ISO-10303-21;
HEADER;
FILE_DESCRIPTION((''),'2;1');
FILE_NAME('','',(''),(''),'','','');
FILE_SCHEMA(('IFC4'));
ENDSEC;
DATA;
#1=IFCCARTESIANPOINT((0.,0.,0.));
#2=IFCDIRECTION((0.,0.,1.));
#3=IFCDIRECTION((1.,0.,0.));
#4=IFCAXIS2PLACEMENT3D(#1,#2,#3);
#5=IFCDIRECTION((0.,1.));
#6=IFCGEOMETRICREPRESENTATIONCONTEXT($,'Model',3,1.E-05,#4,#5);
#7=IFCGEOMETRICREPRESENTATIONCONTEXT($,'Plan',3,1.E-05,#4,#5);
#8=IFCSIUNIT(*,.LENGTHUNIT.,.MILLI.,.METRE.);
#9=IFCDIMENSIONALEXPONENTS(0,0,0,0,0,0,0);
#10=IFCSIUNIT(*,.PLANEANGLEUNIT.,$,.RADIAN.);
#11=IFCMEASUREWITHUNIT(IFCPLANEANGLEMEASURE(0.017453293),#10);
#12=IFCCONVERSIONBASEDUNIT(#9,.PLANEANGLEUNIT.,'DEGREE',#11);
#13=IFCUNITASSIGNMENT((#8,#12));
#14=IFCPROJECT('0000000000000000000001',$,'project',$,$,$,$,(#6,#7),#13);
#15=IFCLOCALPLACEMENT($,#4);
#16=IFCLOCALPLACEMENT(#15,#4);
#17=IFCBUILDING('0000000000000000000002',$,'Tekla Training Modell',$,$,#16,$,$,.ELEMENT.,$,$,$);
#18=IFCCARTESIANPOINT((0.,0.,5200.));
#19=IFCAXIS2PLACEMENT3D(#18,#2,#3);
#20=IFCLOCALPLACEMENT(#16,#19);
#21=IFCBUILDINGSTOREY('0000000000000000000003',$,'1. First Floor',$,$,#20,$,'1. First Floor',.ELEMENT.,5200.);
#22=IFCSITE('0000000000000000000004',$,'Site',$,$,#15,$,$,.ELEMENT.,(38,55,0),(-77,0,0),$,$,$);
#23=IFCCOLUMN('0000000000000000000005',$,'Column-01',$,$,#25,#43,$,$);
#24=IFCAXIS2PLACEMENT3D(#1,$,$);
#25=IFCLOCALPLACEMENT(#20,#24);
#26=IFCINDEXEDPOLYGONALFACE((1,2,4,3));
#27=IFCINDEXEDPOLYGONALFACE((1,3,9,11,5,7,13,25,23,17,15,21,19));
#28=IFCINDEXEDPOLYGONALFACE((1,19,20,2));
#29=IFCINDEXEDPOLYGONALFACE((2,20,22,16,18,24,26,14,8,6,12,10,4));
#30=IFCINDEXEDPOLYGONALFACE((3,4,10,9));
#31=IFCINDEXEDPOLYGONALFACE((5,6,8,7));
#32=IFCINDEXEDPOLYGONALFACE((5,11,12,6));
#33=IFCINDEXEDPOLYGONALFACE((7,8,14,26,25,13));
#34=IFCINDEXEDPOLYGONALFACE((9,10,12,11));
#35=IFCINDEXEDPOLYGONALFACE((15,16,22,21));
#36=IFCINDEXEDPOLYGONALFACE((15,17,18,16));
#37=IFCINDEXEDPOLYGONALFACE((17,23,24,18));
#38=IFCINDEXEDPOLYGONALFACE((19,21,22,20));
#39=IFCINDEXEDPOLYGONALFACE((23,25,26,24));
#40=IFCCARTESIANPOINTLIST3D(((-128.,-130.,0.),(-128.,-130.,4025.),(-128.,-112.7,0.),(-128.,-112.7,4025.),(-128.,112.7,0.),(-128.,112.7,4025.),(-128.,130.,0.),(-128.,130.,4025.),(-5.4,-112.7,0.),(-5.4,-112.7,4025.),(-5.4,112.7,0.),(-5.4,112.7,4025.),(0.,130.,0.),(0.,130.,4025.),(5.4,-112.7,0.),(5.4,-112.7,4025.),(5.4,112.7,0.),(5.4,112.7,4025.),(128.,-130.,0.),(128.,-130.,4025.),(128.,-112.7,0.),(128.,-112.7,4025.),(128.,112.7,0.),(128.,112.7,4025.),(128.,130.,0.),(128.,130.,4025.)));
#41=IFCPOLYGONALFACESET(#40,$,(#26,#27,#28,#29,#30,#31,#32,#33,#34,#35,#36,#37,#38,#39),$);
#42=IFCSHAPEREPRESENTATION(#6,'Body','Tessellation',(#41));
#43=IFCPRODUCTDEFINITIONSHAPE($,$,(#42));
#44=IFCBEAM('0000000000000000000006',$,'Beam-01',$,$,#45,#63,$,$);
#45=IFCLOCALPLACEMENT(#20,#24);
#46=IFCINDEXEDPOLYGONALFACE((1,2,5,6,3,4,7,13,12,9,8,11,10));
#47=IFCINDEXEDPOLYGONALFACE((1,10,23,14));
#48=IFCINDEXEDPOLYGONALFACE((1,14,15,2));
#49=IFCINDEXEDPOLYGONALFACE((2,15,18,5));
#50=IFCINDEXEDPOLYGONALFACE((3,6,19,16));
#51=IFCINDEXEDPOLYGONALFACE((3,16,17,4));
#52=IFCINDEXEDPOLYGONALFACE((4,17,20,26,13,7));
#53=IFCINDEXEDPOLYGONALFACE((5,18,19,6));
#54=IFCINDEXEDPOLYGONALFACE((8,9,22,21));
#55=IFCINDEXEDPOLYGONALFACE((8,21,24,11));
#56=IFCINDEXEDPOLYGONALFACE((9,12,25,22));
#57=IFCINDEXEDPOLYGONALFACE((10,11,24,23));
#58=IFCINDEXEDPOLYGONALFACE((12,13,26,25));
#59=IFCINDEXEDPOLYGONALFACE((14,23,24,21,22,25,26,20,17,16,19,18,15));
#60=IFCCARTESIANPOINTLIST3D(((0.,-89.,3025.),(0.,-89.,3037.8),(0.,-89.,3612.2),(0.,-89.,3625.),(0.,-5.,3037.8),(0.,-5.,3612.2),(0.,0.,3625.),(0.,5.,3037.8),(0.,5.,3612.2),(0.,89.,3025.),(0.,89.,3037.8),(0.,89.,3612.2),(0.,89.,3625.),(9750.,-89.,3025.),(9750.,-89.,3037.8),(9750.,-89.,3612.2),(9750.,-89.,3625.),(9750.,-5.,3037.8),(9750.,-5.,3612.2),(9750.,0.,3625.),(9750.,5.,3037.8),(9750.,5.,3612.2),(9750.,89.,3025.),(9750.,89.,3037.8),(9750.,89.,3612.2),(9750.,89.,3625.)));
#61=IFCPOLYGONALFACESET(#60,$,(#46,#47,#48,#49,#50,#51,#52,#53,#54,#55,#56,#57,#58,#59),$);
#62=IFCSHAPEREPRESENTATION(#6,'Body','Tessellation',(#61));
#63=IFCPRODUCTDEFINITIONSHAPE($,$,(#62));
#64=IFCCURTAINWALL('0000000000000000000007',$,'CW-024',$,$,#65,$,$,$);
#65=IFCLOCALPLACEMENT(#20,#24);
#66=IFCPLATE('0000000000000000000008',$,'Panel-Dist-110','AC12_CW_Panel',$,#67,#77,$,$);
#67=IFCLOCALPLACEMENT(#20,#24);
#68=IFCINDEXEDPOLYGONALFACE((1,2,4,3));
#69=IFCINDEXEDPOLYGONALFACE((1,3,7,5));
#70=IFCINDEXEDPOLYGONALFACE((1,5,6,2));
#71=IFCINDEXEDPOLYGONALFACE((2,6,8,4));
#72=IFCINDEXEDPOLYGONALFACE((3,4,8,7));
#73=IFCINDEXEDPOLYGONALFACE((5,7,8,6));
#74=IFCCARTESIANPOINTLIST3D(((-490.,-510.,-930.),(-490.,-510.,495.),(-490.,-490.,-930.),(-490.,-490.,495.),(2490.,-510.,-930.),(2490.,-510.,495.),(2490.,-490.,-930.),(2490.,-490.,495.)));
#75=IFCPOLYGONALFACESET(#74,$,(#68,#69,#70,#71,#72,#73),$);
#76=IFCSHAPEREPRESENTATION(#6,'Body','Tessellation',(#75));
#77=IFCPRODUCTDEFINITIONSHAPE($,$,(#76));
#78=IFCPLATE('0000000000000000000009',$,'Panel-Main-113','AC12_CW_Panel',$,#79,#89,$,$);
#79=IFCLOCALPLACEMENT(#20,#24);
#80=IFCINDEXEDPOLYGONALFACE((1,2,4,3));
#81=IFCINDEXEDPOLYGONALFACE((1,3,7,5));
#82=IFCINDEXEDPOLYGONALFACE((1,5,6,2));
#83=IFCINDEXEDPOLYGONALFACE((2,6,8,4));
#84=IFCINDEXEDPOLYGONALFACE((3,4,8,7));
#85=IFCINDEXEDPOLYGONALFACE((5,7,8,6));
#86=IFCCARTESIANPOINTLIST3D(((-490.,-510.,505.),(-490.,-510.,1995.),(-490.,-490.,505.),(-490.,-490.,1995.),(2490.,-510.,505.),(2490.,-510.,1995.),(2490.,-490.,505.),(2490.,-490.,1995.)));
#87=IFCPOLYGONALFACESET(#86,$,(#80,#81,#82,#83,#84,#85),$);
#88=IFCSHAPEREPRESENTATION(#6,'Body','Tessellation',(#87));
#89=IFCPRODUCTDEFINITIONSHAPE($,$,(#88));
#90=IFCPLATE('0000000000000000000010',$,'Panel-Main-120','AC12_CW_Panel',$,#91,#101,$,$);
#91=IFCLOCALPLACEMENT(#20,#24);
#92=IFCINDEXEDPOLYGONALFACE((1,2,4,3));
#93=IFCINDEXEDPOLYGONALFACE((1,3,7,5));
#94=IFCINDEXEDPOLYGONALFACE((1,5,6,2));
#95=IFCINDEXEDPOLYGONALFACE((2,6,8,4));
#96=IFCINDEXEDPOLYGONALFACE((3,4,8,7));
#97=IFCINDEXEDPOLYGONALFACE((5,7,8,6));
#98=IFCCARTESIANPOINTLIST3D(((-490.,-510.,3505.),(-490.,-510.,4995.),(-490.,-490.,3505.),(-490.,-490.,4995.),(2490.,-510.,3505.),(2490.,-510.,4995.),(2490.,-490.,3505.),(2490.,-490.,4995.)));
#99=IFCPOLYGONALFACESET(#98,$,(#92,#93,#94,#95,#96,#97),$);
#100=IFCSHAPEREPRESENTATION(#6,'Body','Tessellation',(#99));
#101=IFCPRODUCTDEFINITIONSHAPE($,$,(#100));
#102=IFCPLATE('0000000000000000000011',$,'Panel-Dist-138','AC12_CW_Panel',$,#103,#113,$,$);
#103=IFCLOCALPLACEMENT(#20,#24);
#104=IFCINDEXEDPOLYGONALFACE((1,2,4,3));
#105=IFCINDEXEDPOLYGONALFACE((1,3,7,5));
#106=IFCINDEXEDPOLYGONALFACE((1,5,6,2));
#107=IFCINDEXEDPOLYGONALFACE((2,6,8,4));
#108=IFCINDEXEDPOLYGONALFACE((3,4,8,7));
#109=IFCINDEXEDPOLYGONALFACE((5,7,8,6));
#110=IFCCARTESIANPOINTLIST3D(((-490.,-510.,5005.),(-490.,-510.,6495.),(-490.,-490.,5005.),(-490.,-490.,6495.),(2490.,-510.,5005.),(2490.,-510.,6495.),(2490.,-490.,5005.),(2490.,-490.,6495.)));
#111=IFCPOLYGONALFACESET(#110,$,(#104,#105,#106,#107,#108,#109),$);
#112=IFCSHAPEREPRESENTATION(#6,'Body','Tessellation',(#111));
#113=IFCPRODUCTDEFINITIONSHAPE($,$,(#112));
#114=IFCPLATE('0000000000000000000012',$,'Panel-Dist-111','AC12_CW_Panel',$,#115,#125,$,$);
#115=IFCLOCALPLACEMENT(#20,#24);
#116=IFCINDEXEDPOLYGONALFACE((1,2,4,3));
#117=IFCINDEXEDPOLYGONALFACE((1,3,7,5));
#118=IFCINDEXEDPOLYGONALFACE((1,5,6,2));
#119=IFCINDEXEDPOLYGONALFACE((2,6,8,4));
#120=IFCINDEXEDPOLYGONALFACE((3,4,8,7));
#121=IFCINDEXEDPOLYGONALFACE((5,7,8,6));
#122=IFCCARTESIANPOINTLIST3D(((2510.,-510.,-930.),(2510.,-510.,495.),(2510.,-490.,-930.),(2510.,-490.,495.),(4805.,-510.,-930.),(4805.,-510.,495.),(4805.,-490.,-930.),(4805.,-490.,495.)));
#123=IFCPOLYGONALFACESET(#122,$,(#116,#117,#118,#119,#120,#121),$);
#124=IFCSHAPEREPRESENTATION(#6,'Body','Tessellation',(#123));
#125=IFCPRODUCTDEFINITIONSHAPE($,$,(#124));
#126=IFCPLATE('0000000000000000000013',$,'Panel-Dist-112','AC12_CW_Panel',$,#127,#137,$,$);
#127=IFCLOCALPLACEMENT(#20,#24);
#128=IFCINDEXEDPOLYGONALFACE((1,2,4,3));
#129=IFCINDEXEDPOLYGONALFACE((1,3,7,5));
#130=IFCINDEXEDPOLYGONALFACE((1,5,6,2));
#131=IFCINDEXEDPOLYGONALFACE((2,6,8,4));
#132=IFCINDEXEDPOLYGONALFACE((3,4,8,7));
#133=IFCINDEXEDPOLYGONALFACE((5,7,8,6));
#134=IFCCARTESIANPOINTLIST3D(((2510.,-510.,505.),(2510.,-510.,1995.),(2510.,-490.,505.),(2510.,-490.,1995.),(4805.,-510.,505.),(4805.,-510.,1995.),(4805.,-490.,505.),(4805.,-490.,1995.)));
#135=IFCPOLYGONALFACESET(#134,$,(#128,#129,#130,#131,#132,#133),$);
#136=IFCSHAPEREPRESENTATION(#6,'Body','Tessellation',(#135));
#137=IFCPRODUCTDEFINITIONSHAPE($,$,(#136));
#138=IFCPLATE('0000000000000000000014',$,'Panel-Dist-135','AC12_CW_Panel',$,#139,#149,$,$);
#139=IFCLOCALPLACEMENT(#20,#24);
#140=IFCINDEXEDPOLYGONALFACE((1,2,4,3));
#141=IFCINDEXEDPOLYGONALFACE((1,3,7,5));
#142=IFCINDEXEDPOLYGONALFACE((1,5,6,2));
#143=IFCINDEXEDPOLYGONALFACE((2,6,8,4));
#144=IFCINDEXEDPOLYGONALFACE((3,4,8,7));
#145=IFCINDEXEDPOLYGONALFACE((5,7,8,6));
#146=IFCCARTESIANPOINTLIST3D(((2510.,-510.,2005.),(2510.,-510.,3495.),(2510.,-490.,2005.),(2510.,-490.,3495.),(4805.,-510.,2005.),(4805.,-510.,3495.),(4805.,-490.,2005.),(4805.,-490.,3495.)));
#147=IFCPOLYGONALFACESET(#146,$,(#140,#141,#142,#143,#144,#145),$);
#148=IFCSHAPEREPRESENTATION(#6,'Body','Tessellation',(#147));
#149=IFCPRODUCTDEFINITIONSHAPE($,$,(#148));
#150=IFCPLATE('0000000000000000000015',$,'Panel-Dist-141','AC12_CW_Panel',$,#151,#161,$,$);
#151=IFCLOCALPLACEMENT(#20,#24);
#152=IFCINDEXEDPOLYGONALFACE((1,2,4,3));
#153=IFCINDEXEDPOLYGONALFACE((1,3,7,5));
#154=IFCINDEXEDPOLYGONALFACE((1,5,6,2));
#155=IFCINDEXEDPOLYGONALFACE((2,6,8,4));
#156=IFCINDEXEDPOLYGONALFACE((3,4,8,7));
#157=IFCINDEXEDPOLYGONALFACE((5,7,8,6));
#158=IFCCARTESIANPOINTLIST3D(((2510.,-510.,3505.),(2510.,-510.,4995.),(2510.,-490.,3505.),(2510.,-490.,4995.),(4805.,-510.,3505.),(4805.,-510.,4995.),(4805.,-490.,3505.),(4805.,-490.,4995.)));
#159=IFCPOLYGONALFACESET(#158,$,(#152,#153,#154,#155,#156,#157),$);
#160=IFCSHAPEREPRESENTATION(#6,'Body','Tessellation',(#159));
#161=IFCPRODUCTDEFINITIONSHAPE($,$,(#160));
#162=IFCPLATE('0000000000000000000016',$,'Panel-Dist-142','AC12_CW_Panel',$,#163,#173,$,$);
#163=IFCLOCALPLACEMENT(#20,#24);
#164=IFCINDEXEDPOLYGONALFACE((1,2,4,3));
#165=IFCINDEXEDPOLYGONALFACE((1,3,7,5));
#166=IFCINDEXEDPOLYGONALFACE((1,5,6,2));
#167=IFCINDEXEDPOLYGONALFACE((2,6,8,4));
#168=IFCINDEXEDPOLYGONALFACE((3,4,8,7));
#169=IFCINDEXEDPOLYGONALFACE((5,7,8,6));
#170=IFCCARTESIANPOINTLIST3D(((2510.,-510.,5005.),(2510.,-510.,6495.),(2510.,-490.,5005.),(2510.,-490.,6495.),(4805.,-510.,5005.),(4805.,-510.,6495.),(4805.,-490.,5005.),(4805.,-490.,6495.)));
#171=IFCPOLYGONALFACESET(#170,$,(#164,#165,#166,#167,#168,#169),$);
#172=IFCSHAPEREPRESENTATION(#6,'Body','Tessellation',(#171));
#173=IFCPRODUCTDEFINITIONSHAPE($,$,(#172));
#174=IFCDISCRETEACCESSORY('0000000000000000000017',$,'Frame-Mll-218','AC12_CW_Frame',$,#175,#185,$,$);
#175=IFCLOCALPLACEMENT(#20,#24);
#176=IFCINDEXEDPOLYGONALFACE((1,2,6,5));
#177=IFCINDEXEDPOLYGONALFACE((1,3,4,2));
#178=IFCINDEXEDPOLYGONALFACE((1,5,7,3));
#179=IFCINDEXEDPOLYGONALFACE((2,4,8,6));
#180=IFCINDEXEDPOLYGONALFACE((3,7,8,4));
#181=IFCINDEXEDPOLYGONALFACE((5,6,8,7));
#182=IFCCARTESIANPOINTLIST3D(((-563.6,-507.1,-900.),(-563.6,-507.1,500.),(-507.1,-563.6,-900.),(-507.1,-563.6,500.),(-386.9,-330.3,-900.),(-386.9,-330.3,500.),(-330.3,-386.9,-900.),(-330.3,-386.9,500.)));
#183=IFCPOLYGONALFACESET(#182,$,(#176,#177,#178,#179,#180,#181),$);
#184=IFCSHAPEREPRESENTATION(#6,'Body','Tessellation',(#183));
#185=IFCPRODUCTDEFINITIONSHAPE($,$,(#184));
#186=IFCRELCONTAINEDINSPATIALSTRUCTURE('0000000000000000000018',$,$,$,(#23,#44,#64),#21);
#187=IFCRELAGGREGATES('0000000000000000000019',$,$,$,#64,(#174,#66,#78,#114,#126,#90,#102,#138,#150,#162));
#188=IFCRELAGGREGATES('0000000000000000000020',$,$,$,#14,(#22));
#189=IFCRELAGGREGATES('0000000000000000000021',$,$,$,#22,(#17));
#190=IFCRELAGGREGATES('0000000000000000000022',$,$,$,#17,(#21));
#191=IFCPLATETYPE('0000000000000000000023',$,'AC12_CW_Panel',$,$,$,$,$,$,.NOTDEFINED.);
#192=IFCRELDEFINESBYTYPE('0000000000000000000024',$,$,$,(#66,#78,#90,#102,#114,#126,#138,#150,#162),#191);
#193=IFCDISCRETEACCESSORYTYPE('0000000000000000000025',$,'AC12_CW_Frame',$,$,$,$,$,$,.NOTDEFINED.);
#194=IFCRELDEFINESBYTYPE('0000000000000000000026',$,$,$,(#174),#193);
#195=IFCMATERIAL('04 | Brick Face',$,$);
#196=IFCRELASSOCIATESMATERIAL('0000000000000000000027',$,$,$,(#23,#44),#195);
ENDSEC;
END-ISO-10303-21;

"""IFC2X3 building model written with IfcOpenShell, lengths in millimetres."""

from ifc_helpers import new_model, entity, si_unit, converted_unit, direction, frame, origin_with_axes, place, context, project, spatial, polyline, outline, extrude, source, transform, mapped, material, type_object, element, aggregate, save


model = new_model("IFC2X3")

# Units and contexts
model_context = context("Model", 3, precision=1e-05, world=origin_with_axes(), true_north=direction((0.0, 1.0)))
plan_context = context("Plan", 3, precision=1e-05, world=origin_with_axes(), true_north=direction((0.0, 1.0)))
ifc_project = project(units=[si_unit("LENGTHUNIT", "METRE", prefix="MILLI"), converted_unit("PLANEANGLEUNIT", "DEGREE", entity("IfcPlaneAngleMeasure", 0.017453293), si_unit("PLANEANGLEUNIT", "RADIAN"), dimensions=[0, 0, 0, 0, 0, 0, 0])], contexts=[model_context, plan_context])

# Site, building, storey
site_placement = place(None, origin_with_axes())
site = spatial("IfcSite", under=ifc_project, at=site_placement, Name="Site", CompositionType="ELEMENT", RefLatitude=(38, 55, 0), RefLongitude=(-77, 0, 0))
building_placement = place(site_placement, origin_with_axes())
building = spatial("IfcBuilding", under=site, at=building_placement, Name="Tekla Training Modell", CompositionType="ELEMENT")
storey_placement = place(building_placement, frame((0.0, 0.0, 5200.0), z_axis=(0.0, 0.0, 1.0), x_axis=(1.0, 0.0, 0.0)))
storey = spatial("IfcBuildingStorey", under=building, at=storey_placement, Name="1. First Floor", LongName="1. First Floor", CompositionType="ELEMENT", Elevation=5200.0)

# Column
ifc_material = material(Name="04 | Brick Face")
column_placement = place(storey_placement, origin_with_axes())
element("IfcColumn", 1, at=column_placement, inside=storey, material=ifc_material, Name="Column-01", context=model_context, shape_type="SweptSolid", body=[
    extrude(outline(polyline([(0.0, 130.0), (-128.0, 130.0), (-128.0, 112.7), (-5.3, 112.7), (-5.3, -112.7), (-128.0, -112.7), (-128.0, -130.0), (128.0, -130.0), (128.0, -112.7), (5.3, -112.7), (5.3, 112.7), (128.0, 112.7), (128.0, 130.0), (0.0, 130.0)])), origin_with_axes(), (0.0, 0.0, 1.0), 4025.0),
])

# Beam
beam_placement = place(storey_placement, frame((0.0, 0.0, 3325.0), z_axis=(0.0, 0.0, 1.0), x_axis=(0.0, -1.0, 0.0)))
element("IfcBeam", 2, at=beam_placement, inside=storey, material=ifc_material, Name="Beam-01", context=model_context, shape_type="SweptSolid", body=[
    extrude(outline(polyline([(0.0, 300.0), (-89.0, 300.0), (-89.0, 287.2), (-5.0, 287.2), (-5.0, -287.2), (-89.0, -287.2), (-89.0, -300.0), (89.0, -300.0), (89.0, -287.2), (5.0, -287.2), (5.0, 287.2), (89.0, 287.2), (89.0, 300.0), (0.0, 300.0)])), frame((0.0, 9750.0, 0.0), z_axis=(0.0, -1.0, 0.0), x_axis=(1.0, 0.0, 0.0)), (0.0, 0.0, 1.0), 9750.0),
])

# Curtain wall, plates, discrete accessory
curtain_wall_placement = place(storey_placement, frame((-500.0, 6800.2, -1000.0), z_axis=(0.0, 0.0, 1.0), x_axis=(0.0, -1.0, 0.0)))
curtain_wall = element("IfcCurtainWall", 3, at=curtain_wall_placement, inside=storey, Name="CW-024")
plate_type = type_object("IfcPlateType", Name="AC12_CW_Panel", PredefinedType="NOTDEFINED")
shared_shape_1 = source(origin_with_axes(), model_context, "Body", "SweptSolid", [
    extrude(outline(polyline([(0.0, 0.0), (2980.0, 0.0), (2980.0, -20.0), (0.0, -20.0), (0.0, 0.0)])), origin_with_axes(), (0.0, 0.0, 1.0), 1425.0),
])
plate_1_placement = place(storey_placement, frame((-490.0, -490.0, -930.0), z_axis=(0.0, 0.0, 1.0), x_axis=(1.0, 0.0, 0.0)))
plate_1 = element("IfcPlate", 4, at=plate_1_placement, type_object=plate_type, Name="Panel-Dist-110", Description="AC12_CW_Panel", context=model_context, shape_type="MappedRepresentation", body=[
    mapped(shared_shape_1, transform((0.0, 0.0, 0.0), scale=1.0)),
])
shared_shape_2 = source(origin_with_axes(), model_context, "Body", "SweptSolid", [
    extrude(outline(polyline([(0.0, 0.0), (2980.0, 0.0), (2980.0, -20.0), (0.0, -20.0), (0.0, 0.0)])), origin_with_axes(), (0.0, 0.0, 1.0), 1490.0),
])
plate_2_placement = place(storey_placement, frame((-490.0, -490.0, 505.0), z_axis=(0.0, 0.0, 1.0), x_axis=(1.0, 0.0, 0.0)))
plate_2 = element("IfcPlate", 5, at=plate_2_placement, type_object=plate_type, Name="Panel-Main-113", Description="AC12_CW_Panel", context=model_context, shape_type="MappedRepresentation", body=[
    mapped(shared_shape_2, transform((0.0, 0.0, 0.0), scale=1.0)),
])
plate_3_placement = place(storey_placement, frame((-490.0, -490.0, 3505.0), z_axis=(0.0, 0.0, 1.0), x_axis=(1.0, 0.0, 0.0)))
plate_3 = element("IfcPlate", 6, at=plate_3_placement, type_object=plate_type, Name="Panel-Main-120", Description="AC12_CW_Panel", context=model_context, shape_type="MappedRepresentation", body=[
    mapped(shared_shape_2, transform((0.0, 0.0, 0.0), scale=1.0)),
])
plate_4_placement = place(storey_placement, frame((-490.0, -490.0, 5005.0), z_axis=(0.0, 0.0, 1.0), x_axis=(1.0, 0.0, 0.0)))
plate_4 = element("IfcPlate", 7, at=plate_4_placement, type_object=plate_type, Name="Panel-Dist-138", Description="AC12_CW_Panel", context=model_context, shape_type="MappedRepresentation", body=[
    mapped(shared_shape_2, transform((0.0, 0.0, 0.0), scale=1.0)),
])
shared_shape_3 = source(origin_with_axes(), model_context, "Body", "SweptSolid", [
    extrude(outline(polyline([(0.0, 0.0), (2295.0, 0.0), (2295.0, -20.0), (0.0, -20.0), (0.0, 0.0)])), origin_with_axes(), (0.0, 0.0, 1.0), 1425.0),
])
plate_5_placement = place(storey_placement, frame((2510.0, -490.0, -930.0), z_axis=(0.0, 0.0, 1.0), x_axis=(1.0, 0.0, 0.0)))
plate_5 = element("IfcPlate", 8, at=plate_5_placement, type_object=plate_type, Name="Panel-Dist-111", Description="AC12_CW_Panel", context=model_context, shape_type="MappedRepresentation", body=[
    mapped(shared_shape_3, transform((0.0, 0.0, 0.0), scale=1.0)),
])
shared_shape_4 = source(origin_with_axes(), model_context, "Body", "SweptSolid", [
    extrude(outline(polyline([(0.0, 0.0), (2295.0, 0.0), (2295.0, -20.0), (0.0, -20.0), (0.0, 0.0)])), origin_with_axes(), (0.0, 0.0, 1.0), 1490.0),
])
plate_6_placement = place(storey_placement, frame((2510.0, -490.0, 505.0), z_axis=(0.0, 0.0, 1.0), x_axis=(1.0, 0.0, 0.0)))
plate_6 = element("IfcPlate", 9, at=plate_6_placement, type_object=plate_type, Name="Panel-Dist-112", Description="AC12_CW_Panel", context=model_context, shape_type="MappedRepresentation", body=[
    mapped(shared_shape_4, transform((0.0, 0.0, 0.0), scale=1.0)),
])
plate_7_placement = place(storey_placement, frame((2510.0, -490.0, 2005.0), z_axis=(0.0, 0.0, 1.0), x_axis=(1.0, 0.0, 0.0)))
plate_7 = element("IfcPlate", 10, at=plate_7_placement, type_object=plate_type, Name="Panel-Dist-135", Description="AC12_CW_Panel", context=model_context, shape_type="MappedRepresentation", body=[
    mapped(shared_shape_4, transform((0.0, 0.0, 0.0), scale=1.0)),
])
plate_8_placement = place(storey_placement, frame((2510.0, -490.0, 3505.0), z_axis=(0.0, 0.0, 1.0), x_axis=(1.0, 0.0, 0.0)))
plate_8 = element("IfcPlate", 11, at=plate_8_placement, type_object=plate_type, Name="Panel-Dist-141", Description="AC12_CW_Panel", context=model_context, shape_type="MappedRepresentation", body=[
    mapped(shared_shape_4, transform((0.0, 0.0, 0.0), scale=1.0)),
])
plate_9_placement = place(storey_placement, frame((2510.0, -490.0, 5005.0), z_axis=(0.0, 0.0, 1.0), x_axis=(1.0, 0.0, 0.0)))
plate_9 = element("IfcPlate", 12, at=plate_9_placement, type_object=plate_type, Name="Panel-Dist-142", Description="AC12_CW_Panel", context=model_context, shape_type="MappedRepresentation", body=[
    mapped(shared_shape_4, transform((0.0, 0.0, 0.0), scale=1.0)),
])
discrete_accessory_type = type_object("IfcDiscreteAccessoryType", Name="AC12_CW_Frame")
shared_shape_5 = source(origin_with_axes(), model_context, "Body", "SweptSolid", [
    extrude(outline(polyline([(0.0, 0.0), (250.0, 0.0), (250.0, -1400.0), (0.0, -1400.0), (0.0, 0.0)])), origin_with_axes(), (0.0, 0.0, 1.0), 80.0),
])
discrete_accessory_1_placement = place(storey_placement, frame((-386.9, -330.3, -900.0), z_axis=(0.707107, -0.707107, 0.0), x_axis=(-0.707107, -0.707107, 0.0)))
discrete_accessory_1 = element("IfcDiscreteAccessory", 13, at=discrete_accessory_1_placement, type_object=discrete_accessory_type, Name="Frame-Mll-218", Description="AC12_CW_Frame", context=model_context, shape_type="MappedRepresentation", body=[
    mapped(shared_shape_5, transform((0.0, 0.0, 0.0), scale=1.0)),
])
aggregate(curtain_wall, [discrete_accessory_1, plate_1, plate_2, plate_5, plate_6, plate_3, plate_4, plate_7, plate_8, plate_9])

save(model, "model.ifc")
